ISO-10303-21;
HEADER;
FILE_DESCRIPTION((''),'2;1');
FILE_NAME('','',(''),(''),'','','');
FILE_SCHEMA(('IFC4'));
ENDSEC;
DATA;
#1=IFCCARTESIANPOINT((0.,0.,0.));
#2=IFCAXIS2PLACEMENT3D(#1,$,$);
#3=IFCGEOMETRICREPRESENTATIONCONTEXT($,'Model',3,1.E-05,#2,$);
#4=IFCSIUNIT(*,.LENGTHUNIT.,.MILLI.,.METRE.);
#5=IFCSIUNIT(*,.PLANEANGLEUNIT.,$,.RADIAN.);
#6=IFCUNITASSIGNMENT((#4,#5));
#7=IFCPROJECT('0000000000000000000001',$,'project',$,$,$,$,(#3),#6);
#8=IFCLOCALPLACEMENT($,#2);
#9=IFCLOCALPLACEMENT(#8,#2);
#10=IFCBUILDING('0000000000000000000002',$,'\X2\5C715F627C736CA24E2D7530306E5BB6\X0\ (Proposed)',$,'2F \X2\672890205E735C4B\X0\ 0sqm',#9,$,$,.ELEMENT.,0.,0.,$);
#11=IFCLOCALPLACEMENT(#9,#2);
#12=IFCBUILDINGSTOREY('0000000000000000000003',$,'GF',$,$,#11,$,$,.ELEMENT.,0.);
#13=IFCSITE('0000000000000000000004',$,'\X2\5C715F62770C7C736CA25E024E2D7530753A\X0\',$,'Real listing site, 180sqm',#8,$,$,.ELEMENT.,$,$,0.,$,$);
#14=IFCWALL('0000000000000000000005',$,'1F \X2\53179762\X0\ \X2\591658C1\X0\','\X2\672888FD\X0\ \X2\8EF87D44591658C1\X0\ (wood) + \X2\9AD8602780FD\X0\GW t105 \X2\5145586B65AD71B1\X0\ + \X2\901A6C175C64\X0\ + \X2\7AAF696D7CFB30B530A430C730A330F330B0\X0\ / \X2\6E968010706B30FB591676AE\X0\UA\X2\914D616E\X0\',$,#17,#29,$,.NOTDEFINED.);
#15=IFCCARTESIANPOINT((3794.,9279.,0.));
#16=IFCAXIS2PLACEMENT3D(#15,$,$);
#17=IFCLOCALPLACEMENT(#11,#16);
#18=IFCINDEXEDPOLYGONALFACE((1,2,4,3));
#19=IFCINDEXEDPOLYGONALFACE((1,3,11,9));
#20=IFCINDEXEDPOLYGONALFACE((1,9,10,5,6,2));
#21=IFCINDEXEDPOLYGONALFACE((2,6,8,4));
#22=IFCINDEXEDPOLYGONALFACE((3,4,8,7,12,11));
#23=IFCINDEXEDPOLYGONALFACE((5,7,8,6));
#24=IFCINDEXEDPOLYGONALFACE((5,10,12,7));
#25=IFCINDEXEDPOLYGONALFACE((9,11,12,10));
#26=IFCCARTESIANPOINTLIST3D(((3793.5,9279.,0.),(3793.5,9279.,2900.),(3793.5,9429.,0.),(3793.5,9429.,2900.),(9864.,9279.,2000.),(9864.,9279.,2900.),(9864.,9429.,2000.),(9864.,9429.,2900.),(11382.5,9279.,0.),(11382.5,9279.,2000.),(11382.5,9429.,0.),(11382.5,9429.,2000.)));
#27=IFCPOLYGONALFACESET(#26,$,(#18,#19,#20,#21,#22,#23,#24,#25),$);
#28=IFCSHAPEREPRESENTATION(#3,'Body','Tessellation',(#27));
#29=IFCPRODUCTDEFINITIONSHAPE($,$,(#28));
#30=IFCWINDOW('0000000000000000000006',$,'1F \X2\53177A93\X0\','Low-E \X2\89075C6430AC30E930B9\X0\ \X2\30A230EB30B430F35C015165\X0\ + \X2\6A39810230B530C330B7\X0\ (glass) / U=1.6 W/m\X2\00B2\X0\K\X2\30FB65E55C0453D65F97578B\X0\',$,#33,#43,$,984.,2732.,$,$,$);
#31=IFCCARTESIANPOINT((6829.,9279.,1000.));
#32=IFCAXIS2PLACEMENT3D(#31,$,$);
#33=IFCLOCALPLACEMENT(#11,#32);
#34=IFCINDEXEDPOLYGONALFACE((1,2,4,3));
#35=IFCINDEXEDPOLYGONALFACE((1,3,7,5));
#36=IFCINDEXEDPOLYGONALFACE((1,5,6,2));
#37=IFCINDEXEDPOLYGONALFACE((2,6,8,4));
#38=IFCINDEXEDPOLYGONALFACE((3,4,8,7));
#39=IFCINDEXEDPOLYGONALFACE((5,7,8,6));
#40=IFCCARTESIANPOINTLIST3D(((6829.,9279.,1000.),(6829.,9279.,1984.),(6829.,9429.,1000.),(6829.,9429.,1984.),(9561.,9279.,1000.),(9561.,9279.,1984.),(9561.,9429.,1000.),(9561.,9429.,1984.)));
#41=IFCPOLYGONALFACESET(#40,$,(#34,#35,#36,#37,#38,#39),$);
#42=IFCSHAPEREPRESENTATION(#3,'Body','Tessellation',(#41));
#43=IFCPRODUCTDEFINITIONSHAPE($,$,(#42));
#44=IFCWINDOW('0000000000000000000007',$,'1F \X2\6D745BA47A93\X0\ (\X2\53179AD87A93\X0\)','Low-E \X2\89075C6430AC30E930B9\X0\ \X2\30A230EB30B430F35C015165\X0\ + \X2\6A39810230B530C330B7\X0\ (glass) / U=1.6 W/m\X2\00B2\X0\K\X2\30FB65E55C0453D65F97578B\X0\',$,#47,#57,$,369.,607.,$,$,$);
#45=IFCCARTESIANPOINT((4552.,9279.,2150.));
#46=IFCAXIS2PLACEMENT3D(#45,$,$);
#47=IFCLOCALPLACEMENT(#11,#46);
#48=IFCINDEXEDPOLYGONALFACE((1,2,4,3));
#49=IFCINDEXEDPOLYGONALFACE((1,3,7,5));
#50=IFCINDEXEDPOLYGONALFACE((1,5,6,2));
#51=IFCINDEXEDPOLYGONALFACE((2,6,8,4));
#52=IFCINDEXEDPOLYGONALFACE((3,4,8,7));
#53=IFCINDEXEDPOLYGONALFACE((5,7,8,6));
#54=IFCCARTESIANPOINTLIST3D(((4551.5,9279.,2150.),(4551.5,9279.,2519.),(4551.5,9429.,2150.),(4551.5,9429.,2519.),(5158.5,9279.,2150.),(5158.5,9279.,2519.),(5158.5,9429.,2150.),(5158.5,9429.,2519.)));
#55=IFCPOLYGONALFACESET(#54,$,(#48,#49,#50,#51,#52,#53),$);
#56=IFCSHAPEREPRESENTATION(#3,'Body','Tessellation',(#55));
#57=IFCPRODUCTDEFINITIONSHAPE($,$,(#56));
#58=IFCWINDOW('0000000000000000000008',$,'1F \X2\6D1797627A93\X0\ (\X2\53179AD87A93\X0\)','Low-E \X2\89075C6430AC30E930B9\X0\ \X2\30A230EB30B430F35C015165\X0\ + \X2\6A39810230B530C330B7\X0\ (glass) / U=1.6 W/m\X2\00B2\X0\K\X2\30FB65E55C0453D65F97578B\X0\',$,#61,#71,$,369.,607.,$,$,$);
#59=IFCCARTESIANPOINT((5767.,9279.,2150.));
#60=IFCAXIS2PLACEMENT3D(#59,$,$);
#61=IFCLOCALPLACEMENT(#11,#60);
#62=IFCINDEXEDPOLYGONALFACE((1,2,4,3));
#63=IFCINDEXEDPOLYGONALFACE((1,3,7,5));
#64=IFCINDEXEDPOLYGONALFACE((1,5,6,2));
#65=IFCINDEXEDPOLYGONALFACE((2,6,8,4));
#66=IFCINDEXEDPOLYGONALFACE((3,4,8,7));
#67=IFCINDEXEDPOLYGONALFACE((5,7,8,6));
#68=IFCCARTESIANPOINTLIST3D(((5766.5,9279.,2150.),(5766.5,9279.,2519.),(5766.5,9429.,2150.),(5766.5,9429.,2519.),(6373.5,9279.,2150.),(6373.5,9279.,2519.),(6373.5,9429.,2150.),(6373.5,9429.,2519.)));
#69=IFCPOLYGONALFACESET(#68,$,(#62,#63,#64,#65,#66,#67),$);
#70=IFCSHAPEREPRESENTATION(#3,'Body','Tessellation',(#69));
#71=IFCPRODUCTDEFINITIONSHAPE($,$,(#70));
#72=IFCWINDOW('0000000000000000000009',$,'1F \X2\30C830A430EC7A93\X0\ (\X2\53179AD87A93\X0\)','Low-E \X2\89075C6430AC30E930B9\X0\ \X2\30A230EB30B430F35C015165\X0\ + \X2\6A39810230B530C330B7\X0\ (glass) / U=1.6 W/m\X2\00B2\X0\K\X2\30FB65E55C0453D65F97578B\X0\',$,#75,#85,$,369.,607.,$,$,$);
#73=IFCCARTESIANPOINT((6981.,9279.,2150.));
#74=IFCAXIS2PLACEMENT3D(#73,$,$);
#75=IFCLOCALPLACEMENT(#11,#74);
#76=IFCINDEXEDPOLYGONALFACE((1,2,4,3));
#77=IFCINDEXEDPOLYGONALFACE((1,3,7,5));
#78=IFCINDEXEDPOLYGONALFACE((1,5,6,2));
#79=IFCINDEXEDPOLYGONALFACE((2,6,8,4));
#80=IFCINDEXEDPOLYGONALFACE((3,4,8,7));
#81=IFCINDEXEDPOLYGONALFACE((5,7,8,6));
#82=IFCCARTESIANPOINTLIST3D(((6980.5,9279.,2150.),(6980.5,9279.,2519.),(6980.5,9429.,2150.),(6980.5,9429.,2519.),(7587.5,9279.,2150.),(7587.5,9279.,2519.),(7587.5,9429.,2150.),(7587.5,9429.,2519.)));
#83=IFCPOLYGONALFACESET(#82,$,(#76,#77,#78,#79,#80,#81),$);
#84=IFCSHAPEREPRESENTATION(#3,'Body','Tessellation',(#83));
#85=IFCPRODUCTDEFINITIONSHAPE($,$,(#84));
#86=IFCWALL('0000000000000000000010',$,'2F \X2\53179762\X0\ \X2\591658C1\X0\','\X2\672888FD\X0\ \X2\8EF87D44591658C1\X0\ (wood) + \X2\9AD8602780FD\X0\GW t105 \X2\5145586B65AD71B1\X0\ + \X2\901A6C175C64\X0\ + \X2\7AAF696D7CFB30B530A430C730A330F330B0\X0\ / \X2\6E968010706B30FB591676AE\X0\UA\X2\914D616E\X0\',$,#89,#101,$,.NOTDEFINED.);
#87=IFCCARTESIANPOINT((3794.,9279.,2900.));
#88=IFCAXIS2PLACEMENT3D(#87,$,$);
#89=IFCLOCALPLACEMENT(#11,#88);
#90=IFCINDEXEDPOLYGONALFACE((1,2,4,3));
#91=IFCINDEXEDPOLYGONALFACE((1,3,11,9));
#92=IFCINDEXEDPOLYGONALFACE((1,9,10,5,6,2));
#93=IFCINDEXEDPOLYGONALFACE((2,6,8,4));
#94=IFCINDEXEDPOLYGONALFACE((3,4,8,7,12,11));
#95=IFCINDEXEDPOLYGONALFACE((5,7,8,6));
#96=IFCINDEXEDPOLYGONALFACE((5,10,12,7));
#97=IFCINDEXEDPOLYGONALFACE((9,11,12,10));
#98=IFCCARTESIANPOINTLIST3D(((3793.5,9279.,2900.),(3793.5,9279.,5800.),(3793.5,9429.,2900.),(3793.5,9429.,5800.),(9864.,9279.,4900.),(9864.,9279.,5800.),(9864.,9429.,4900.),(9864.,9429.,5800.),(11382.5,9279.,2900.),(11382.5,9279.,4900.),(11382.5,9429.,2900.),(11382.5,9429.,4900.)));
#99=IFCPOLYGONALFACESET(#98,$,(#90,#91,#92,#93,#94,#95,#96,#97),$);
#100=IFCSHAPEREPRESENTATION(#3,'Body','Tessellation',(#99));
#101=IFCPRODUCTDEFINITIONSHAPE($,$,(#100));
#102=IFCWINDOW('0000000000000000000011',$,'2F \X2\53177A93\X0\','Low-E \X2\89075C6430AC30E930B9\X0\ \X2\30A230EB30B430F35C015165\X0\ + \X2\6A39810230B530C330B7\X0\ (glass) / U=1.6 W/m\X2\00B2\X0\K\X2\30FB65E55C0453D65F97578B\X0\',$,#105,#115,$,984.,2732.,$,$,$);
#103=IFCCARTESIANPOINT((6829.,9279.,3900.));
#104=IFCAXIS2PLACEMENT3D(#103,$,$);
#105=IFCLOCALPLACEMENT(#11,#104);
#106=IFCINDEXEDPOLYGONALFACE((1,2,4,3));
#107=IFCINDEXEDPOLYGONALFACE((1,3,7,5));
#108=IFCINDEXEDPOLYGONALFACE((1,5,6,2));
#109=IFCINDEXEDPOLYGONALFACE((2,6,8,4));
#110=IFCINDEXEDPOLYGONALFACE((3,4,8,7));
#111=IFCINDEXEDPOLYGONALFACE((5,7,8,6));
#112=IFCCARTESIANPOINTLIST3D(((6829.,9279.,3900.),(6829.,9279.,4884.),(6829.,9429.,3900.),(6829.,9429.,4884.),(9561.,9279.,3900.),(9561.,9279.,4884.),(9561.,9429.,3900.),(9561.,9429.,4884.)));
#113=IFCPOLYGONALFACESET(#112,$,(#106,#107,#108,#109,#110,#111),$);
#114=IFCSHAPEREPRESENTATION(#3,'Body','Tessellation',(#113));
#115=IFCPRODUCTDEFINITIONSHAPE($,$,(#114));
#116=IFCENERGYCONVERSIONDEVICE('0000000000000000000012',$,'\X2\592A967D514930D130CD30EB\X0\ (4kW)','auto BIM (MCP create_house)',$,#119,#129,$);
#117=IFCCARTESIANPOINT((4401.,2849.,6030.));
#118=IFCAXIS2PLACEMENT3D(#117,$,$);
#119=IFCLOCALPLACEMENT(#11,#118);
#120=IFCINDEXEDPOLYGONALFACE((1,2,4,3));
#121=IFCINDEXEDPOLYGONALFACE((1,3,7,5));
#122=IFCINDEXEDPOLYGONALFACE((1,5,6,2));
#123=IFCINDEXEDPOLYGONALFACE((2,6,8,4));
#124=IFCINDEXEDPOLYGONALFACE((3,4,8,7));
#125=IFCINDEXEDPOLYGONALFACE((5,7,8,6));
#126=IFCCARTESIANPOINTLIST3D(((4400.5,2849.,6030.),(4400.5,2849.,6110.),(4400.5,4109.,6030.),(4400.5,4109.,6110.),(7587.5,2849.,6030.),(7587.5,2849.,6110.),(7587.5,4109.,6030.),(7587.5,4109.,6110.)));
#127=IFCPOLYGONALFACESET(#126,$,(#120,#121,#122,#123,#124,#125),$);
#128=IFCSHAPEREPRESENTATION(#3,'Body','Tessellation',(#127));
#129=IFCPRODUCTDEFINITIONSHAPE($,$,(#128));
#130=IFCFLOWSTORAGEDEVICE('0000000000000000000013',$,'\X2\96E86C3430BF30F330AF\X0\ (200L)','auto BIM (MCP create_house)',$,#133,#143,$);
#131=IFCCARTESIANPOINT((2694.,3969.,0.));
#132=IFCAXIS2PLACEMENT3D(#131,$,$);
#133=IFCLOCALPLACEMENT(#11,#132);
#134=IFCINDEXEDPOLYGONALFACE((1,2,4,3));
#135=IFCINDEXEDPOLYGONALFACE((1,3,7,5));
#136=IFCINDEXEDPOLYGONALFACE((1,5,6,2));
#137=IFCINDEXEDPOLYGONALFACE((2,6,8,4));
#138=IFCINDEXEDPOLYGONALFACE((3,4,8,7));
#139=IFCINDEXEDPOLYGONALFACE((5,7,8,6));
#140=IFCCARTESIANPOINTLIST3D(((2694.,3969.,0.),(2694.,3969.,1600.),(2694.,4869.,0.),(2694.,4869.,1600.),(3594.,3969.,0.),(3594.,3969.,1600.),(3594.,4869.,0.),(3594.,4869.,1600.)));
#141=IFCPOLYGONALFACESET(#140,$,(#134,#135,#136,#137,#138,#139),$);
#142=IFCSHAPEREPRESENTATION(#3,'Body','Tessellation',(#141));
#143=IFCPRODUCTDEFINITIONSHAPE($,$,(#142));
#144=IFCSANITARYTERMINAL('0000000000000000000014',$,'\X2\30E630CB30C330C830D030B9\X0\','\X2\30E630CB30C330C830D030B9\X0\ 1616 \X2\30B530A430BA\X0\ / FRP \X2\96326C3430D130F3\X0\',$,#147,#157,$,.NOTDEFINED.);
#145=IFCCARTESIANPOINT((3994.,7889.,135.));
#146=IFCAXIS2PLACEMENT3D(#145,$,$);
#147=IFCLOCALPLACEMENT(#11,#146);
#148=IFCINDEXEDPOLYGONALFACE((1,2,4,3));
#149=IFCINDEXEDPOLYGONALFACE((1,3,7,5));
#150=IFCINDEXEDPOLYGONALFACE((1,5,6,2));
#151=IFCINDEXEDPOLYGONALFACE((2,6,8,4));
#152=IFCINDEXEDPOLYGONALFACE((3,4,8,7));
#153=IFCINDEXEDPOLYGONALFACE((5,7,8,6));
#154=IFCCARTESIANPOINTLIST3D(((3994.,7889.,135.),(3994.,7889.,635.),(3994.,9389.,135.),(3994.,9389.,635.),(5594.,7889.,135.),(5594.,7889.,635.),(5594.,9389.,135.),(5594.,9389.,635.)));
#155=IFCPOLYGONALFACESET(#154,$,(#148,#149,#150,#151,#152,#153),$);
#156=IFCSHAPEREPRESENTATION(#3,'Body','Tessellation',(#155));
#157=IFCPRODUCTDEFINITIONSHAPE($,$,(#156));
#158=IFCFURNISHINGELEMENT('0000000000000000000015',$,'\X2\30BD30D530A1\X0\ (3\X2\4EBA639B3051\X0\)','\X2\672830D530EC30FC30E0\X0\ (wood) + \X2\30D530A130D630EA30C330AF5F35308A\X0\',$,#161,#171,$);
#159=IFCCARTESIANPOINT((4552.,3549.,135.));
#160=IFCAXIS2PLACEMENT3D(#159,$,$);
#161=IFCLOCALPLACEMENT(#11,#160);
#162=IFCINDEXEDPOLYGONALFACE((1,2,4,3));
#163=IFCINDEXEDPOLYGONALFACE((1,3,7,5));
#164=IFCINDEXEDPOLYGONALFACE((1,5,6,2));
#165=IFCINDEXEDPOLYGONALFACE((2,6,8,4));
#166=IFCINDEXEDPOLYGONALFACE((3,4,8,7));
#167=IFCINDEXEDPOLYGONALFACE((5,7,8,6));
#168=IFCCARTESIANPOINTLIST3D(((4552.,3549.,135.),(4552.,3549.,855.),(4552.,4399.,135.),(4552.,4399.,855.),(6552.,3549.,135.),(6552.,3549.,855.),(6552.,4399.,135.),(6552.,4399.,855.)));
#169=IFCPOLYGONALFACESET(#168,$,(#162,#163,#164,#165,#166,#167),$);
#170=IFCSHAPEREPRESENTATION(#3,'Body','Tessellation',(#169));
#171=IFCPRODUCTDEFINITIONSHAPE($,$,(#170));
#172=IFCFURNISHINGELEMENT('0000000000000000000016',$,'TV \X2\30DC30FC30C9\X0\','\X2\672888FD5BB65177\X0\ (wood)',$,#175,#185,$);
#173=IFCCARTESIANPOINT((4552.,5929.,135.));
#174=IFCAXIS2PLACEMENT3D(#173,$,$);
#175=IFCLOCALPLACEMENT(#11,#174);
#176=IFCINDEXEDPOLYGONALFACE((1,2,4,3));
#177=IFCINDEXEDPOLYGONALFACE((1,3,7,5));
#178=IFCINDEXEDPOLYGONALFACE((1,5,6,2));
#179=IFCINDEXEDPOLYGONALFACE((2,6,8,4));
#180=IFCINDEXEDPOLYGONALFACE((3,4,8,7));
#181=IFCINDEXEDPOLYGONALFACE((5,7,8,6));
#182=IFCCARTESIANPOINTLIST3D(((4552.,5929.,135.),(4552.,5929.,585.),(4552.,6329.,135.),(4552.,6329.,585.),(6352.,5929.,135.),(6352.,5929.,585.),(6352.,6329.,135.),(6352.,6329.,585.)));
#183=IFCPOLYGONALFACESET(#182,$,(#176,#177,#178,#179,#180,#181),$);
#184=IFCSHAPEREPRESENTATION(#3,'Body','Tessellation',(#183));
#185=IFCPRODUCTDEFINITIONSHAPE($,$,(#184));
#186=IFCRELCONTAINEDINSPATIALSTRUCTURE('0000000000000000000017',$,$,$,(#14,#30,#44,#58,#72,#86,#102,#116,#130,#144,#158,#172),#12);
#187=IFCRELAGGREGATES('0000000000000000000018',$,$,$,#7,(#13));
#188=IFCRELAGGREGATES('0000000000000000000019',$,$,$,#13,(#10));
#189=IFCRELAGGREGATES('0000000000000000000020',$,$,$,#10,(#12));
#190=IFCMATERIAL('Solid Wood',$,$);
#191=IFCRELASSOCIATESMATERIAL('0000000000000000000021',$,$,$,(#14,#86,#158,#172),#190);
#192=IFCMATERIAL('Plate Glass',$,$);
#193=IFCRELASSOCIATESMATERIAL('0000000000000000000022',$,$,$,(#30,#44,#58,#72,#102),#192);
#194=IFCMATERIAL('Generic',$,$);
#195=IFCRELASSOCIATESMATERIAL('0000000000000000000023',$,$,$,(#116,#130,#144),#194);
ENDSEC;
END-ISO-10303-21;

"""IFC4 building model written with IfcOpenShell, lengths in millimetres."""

from ifc_helpers import new_model, si_unit, frame, frame_2d, origin, place, context, project, spatial, rectangle, extrude, material, element, fill, save


model = new_model("IFC4")

# Units and contexts
model_context = context("Model", 3, precision=1e-05, world=origin())
ifc_project = project(units=[si_unit("LENGTHUNIT", "METRE", prefix="MILLI"), si_unit("PLANEANGLEUNIT", "RADIAN")], contexts=[model_context])

# Site, building, storey
site_placement = place(None, origin())
site = spatial("IfcSite", under=ifc_project, at=site_placement, Name="山形県米沢市中田町", ObjectType="Real listing site, 180sqm", CompositionType="ELEMENT", RefElevation=0.0)
building_placement = place(site_placement, origin())
building = spatial("IfcBuilding", under=site, at=building_placement, Name="山形米沢中田の家 (Proposed)", ObjectType="2F 木造平屋 0sqm", CompositionType="ELEMENT", ElevationOfRefHeight=0.0, ElevationOfTerrain=0.0)
storey_placement = place(building_placement, origin())
storey = spatial("IfcBuildingStorey", under=building, at=storey_placement, Name="GF", CompositionType="ELEMENT", Elevation=0.0)

# Wall, openings, windows
ifc_material_1 = material(Name="Solid Wood")
wall_1_placement = place(storey_placement, frame((3794.0, 9279.0, 0.0)))
wall_1 = element("IfcWall", 1, at=wall_1_placement, inside=storey, material=ifc_material_1, Name="1F 北面 外壁", Description="木製 軸組外壁 (wood) + 高性能GW t105 充填断熱 + 通気層 + 窯業系サイディング / 準耐火・外皮UA配慮", PredefinedType="NOTDEFINED", context=model_context, shape_type="SweptSolid", body=[
    extrude(rectangle(XDim=7589.0, YDim=150.0, at=frame_2d((3794.0, 75.0))), frame((3794.0, 9279.0, 0.0)), (0.0, 0.0, 1.0), 2900.0),
])
opening_1_placement = place(storey_placement, frame((6829.0, 9279.0, 1000.0)))
opening_1 = element("IfcOpeningElement", 2, at=opening_1_placement, cuts=wall_1, PredefinedType="NOTDEFINED", context=model_context, shape_type="SweptSolid", body=[
    extrude(rectangle(XDim=2732.0, YDim=150.0, at=frame_2d((1366.0, 75.0))), frame((6829.0, 9279.0, 1000.0)), (0.0, 0.0, 1.0), 984.0),
])
opening_2_placement = place(storey_placement, frame((4552.0, 9279.0, 2150.0)))
opening_2 = element("IfcOpeningElement", 3, at=opening_2_placement, cuts=wall_1, PredefinedType="NOTDEFINED", context=model_context, shape_type="SweptSolid", body=[
    extrude(rectangle(XDim=607.0, YDim=150.0, at=frame_2d((303.0, 75.0))), frame((4552.0, 9279.0, 2150.0)), (0.0, 0.0, 1.0), 369.0),
])
opening_3_placement = place(storey_placement, frame((5767.0, 9279.0, 2150.0)))
opening_3 = element("IfcOpeningElement", 4, at=opening_3_placement, cuts=wall_1, PredefinedType="NOTDEFINED", context=model_context, shape_type="SweptSolid", body=[
    extrude(rectangle(XDim=607.0, YDim=150.0, at=frame_2d((303.0, 75.0))), frame((5767.0, 9279.0, 2150.0)), (0.0, 0.0, 1.0), 369.0),
])
opening_4_placement = place(storey_placement, frame((6981.0, 9279.0, 2150.0)))
opening_4 = element("IfcOpeningElement", 5, at=opening_4_placement, cuts=wall_1, PredefinedType="NOTDEFINED", context=model_context, shape_type="SweptSolid", body=[
    extrude(rectangle(XDim=607.0, YDim=150.0, at=frame_2d((303.0, 75.0))), frame((6981.0, 9279.0, 2150.0)), (0.0, 0.0, 1.0), 369.0),
])
ifc_material_2 = material(Name="Plate Glass")
window_1_placement = place(storey_placement, frame((6829.0, 9279.0, 1000.0)))
window_1 = element("IfcWindow", 6, at=window_1_placement, inside=storey, material=ifc_material_2, Name="1F 北窓", Description="Low-E 複層ガラス アルゴン封入 + 樹脂サッシ (glass) / U=1.6 W/m²K・日射取得型", OverallHeight=984.0, OverallWidth=2732.0, context=model_context, shape_type="SweptSolid", body=[
    extrude(rectangle(XDim=2732.0, YDim=150.0, at=frame_2d((1366.0, 75.0))), frame((6829.0, 9279.0, 1000.0)), (0.0, 0.0, 1.0), 984.0),
])
fill(opening_1, window_1)
window_2_placement = place(storey_placement, frame((4552.0, 9279.0, 2150.0)))
window_2 = element("IfcWindow", 7, at=window_2_placement, inside=storey, material=ifc_material_2, Name="1F 浴室窓 (北高窓)", Description="Low-E 複層ガラス アルゴン封入 + 樹脂サッシ (glass) / U=1.6 W/m²K・日射取得型", OverallHeight=369.0, OverallWidth=607.0, context=model_context, shape_type="SweptSolid", body=[
    extrude(rectangle(XDim=607.0, YDim=150.0, at=frame_2d((303.0, 75.0))), frame((4552.0, 9279.0, 2150.0)), (0.0, 0.0, 1.0), 369.0),
])
fill(opening_2, window_2)
window_3_placement = place(storey_placement, frame((5767.0, 9279.0, 2150.0)))
window_3 = element("IfcWindow", 8, at=window_3_placement, inside=storey, material=ifc_material_2, Name="1F 洗面窓 (北高窓)", Description="Low-E 複層ガラス アルゴン封入 + 樹脂サッシ (glass) / U=1.6 W/m²K・日射取得型", OverallHeight=369.0, OverallWidth=607.0, context=model_context, shape_type="SweptSolid", body=[
    extrude(rectangle(XDim=607.0, YDim=150.0, at=frame_2d((303.0, 75.0))), frame((5767.0, 9279.0, 2150.0)), (0.0, 0.0, 1.0), 369.0),
])
fill(opening_3, window_3)
window_4_placement = place(storey_placement, frame((6981.0, 9279.0, 2150.0)))
window_4 = element("IfcWindow", 9, at=window_4_placement, inside=storey, material=ifc_material_2, Name="1F トイレ窓 (北高窓)", Description="Low-E 複層ガラス アルゴン封入 + 樹脂サッシ (glass) / U=1.6 W/m²K・日射取得型", OverallHeight=369.0, OverallWidth=607.0, context=model_context, shape_type="SweptSolid", body=[
    extrude(rectangle(XDim=607.0, YDim=150.0, at=frame_2d((303.0, 75.0))), frame((6981.0, 9279.0, 2150.0)), (0.0, 0.0, 1.0), 369.0),
])
fill(opening_4, window_4)

# Wall, opening, window
wall_2_placement = place(storey_placement, frame((3794.0, 9279.0, 2900.0)))
wall_2 = element("IfcWall", 10, at=wall_2_placement, inside=storey, material=ifc_material_1, Name="2F 北面 外壁", Description="木製 軸組外壁 (wood) + 高性能GW t105 充填断熱 + 通気層 + 窯業系サイディング / 準耐火・外皮UA配慮", PredefinedType="NOTDEFINED", context=model_context, shape_type="SweptSolid", body=[
    extrude(rectangle(XDim=7589.0, YDim=150.0, at=frame_2d((3794.0, 75.0))), frame((3794.0, 9279.0, 2900.0)), (0.0, 0.0, 1.0), 2900.0),
])
opening_5_placement = place(storey_placement, frame((6829.0, 9279.0, 3900.0)))
opening_5 = element("IfcOpeningElement", 11, at=opening_5_placement, cuts=wall_2, PredefinedType="NOTDEFINED", context=model_context, shape_type="SweptSolid", body=[
    extrude(rectangle(XDim=2732.0, YDim=150.0, at=frame_2d((1366.0, 75.0))), frame((6829.0, 9279.0, 3900.0)), (0.0, 0.0, 1.0), 984.0),
])
window_5_placement = place(storey_placement, frame((6829.0, 9279.0, 3900.0)))
window_5 = element("IfcWindow", 12, at=window_5_placement, inside=storey, material=ifc_material_2, Name="2F 北窓", Description="Low-E 複層ガラス アルゴン封入 + 樹脂サッシ (glass) / U=1.6 W/m²K・日射取得型", OverallHeight=984.0, OverallWidth=2732.0, context=model_context, shape_type="SweptSolid", body=[
    extrude(rectangle(XDim=2732.0, YDim=150.0, at=frame_2d((1366.0, 75.0))), frame((6829.0, 9279.0, 3900.0)), (0.0, 0.0, 1.0), 984.0),
])
fill(opening_5, window_5)

# Energy conversion device
ifc_material_3 = material(Name="Generic")
energy_conversion_device_placement = place(storey_placement, frame((4401.0, 2849.0, 6030.0)))
element("IfcEnergyConversionDevice", 13, at=energy_conversion_device_placement, inside=storey, material=ifc_material_3, Name="太陽光パネル (4kW)", Description="auto BIM (MCP create_house)", context=model_context, shape_type="SweptSolid", body=[
    extrude(rectangle(XDim=3187.0, YDim=1260.0, at=frame_2d((1593.0, 630.0))), frame((4401.0, 2849.0, 6030.0)), (0.0, 0.0, 1.0), 80.0),
])

# Flow storage device
flow_storage_device_placement = place(storey_placement, frame((2694.0, 3969.0, 0.0)))
element("IfcFlowStorageDevice", 14, at=flow_storage_device_placement, inside=storey, material=ifc_material_3, Name="雨水タンク (200L)", Description="auto BIM (MCP create_house)", context=model_context, shape_type="SweptSolid", body=[
    extrude(rectangle(XDim=900.0, YDim=900.0, at=frame_2d((450.0, 450.0))), frame((2694.0, 3969.0, 0.0)), (0.0, 0.0, 1.0), 1600.0),
])

# Sanitary terminal
sanitary_terminal_placement = place(storey_placement, frame((3994.0, 7889.0, 135.0)))
element("IfcSanitaryTerminal", 15, at=sanitary_terminal_placement, inside=storey, material=ifc_material_3, Name="ユニットバス", Description="ユニットバス 1616 サイズ / FRP 防水パン", PredefinedType="NOTDEFINED", context=model_context, shape_type="SweptSolid", body=[
    extrude(rectangle(XDim=1600.0, YDim=1500.0, at=frame_2d((800.0, 750.0))), frame((3994.0, 7889.0, 135.0)), (0.0, 0.0, 1.0), 500.0),
])

# Furnishing elements
furnishing_1_placement = place(storey_placement, frame((4552.0, 3549.0, 135.0)))
element("IfcFurnishingElement", 16, at=furnishing_1_placement, inside=storey, material=ifc_material_1, Name="ソファ (3人掛け)", Description="木フレーム (wood) + ファブリック張り", context=model_context, shape_type="SweptSolid", body=[
    extrude(rectangle(XDim=2000.0, YDim=850.0, at=frame_2d((1000.0, 425.0))), frame((4552.0, 3549.0, 135.0)), (0.0, 0.0, 1.0), 720.0),
])
furnishing_2_placement = place(storey_placement, frame((4552.0, 5929.0, 135.0)))
element("IfcFurnishingElement", 17, at=furnishing_2_placement, inside=storey, material=ifc_material_1, Name="TV ボード", Description="木製家具 (wood)", context=model_context, shape_type="SweptSolid", body=[
    extrude(rectangle(XDim=1800.0, YDim=400.0, at=frame_2d((900.0, 200.0))), frame((4552.0, 5929.0, 135.0)), (0.0, 0.0, 1.0), 450.0),
])

save(model, "model.ifc")
